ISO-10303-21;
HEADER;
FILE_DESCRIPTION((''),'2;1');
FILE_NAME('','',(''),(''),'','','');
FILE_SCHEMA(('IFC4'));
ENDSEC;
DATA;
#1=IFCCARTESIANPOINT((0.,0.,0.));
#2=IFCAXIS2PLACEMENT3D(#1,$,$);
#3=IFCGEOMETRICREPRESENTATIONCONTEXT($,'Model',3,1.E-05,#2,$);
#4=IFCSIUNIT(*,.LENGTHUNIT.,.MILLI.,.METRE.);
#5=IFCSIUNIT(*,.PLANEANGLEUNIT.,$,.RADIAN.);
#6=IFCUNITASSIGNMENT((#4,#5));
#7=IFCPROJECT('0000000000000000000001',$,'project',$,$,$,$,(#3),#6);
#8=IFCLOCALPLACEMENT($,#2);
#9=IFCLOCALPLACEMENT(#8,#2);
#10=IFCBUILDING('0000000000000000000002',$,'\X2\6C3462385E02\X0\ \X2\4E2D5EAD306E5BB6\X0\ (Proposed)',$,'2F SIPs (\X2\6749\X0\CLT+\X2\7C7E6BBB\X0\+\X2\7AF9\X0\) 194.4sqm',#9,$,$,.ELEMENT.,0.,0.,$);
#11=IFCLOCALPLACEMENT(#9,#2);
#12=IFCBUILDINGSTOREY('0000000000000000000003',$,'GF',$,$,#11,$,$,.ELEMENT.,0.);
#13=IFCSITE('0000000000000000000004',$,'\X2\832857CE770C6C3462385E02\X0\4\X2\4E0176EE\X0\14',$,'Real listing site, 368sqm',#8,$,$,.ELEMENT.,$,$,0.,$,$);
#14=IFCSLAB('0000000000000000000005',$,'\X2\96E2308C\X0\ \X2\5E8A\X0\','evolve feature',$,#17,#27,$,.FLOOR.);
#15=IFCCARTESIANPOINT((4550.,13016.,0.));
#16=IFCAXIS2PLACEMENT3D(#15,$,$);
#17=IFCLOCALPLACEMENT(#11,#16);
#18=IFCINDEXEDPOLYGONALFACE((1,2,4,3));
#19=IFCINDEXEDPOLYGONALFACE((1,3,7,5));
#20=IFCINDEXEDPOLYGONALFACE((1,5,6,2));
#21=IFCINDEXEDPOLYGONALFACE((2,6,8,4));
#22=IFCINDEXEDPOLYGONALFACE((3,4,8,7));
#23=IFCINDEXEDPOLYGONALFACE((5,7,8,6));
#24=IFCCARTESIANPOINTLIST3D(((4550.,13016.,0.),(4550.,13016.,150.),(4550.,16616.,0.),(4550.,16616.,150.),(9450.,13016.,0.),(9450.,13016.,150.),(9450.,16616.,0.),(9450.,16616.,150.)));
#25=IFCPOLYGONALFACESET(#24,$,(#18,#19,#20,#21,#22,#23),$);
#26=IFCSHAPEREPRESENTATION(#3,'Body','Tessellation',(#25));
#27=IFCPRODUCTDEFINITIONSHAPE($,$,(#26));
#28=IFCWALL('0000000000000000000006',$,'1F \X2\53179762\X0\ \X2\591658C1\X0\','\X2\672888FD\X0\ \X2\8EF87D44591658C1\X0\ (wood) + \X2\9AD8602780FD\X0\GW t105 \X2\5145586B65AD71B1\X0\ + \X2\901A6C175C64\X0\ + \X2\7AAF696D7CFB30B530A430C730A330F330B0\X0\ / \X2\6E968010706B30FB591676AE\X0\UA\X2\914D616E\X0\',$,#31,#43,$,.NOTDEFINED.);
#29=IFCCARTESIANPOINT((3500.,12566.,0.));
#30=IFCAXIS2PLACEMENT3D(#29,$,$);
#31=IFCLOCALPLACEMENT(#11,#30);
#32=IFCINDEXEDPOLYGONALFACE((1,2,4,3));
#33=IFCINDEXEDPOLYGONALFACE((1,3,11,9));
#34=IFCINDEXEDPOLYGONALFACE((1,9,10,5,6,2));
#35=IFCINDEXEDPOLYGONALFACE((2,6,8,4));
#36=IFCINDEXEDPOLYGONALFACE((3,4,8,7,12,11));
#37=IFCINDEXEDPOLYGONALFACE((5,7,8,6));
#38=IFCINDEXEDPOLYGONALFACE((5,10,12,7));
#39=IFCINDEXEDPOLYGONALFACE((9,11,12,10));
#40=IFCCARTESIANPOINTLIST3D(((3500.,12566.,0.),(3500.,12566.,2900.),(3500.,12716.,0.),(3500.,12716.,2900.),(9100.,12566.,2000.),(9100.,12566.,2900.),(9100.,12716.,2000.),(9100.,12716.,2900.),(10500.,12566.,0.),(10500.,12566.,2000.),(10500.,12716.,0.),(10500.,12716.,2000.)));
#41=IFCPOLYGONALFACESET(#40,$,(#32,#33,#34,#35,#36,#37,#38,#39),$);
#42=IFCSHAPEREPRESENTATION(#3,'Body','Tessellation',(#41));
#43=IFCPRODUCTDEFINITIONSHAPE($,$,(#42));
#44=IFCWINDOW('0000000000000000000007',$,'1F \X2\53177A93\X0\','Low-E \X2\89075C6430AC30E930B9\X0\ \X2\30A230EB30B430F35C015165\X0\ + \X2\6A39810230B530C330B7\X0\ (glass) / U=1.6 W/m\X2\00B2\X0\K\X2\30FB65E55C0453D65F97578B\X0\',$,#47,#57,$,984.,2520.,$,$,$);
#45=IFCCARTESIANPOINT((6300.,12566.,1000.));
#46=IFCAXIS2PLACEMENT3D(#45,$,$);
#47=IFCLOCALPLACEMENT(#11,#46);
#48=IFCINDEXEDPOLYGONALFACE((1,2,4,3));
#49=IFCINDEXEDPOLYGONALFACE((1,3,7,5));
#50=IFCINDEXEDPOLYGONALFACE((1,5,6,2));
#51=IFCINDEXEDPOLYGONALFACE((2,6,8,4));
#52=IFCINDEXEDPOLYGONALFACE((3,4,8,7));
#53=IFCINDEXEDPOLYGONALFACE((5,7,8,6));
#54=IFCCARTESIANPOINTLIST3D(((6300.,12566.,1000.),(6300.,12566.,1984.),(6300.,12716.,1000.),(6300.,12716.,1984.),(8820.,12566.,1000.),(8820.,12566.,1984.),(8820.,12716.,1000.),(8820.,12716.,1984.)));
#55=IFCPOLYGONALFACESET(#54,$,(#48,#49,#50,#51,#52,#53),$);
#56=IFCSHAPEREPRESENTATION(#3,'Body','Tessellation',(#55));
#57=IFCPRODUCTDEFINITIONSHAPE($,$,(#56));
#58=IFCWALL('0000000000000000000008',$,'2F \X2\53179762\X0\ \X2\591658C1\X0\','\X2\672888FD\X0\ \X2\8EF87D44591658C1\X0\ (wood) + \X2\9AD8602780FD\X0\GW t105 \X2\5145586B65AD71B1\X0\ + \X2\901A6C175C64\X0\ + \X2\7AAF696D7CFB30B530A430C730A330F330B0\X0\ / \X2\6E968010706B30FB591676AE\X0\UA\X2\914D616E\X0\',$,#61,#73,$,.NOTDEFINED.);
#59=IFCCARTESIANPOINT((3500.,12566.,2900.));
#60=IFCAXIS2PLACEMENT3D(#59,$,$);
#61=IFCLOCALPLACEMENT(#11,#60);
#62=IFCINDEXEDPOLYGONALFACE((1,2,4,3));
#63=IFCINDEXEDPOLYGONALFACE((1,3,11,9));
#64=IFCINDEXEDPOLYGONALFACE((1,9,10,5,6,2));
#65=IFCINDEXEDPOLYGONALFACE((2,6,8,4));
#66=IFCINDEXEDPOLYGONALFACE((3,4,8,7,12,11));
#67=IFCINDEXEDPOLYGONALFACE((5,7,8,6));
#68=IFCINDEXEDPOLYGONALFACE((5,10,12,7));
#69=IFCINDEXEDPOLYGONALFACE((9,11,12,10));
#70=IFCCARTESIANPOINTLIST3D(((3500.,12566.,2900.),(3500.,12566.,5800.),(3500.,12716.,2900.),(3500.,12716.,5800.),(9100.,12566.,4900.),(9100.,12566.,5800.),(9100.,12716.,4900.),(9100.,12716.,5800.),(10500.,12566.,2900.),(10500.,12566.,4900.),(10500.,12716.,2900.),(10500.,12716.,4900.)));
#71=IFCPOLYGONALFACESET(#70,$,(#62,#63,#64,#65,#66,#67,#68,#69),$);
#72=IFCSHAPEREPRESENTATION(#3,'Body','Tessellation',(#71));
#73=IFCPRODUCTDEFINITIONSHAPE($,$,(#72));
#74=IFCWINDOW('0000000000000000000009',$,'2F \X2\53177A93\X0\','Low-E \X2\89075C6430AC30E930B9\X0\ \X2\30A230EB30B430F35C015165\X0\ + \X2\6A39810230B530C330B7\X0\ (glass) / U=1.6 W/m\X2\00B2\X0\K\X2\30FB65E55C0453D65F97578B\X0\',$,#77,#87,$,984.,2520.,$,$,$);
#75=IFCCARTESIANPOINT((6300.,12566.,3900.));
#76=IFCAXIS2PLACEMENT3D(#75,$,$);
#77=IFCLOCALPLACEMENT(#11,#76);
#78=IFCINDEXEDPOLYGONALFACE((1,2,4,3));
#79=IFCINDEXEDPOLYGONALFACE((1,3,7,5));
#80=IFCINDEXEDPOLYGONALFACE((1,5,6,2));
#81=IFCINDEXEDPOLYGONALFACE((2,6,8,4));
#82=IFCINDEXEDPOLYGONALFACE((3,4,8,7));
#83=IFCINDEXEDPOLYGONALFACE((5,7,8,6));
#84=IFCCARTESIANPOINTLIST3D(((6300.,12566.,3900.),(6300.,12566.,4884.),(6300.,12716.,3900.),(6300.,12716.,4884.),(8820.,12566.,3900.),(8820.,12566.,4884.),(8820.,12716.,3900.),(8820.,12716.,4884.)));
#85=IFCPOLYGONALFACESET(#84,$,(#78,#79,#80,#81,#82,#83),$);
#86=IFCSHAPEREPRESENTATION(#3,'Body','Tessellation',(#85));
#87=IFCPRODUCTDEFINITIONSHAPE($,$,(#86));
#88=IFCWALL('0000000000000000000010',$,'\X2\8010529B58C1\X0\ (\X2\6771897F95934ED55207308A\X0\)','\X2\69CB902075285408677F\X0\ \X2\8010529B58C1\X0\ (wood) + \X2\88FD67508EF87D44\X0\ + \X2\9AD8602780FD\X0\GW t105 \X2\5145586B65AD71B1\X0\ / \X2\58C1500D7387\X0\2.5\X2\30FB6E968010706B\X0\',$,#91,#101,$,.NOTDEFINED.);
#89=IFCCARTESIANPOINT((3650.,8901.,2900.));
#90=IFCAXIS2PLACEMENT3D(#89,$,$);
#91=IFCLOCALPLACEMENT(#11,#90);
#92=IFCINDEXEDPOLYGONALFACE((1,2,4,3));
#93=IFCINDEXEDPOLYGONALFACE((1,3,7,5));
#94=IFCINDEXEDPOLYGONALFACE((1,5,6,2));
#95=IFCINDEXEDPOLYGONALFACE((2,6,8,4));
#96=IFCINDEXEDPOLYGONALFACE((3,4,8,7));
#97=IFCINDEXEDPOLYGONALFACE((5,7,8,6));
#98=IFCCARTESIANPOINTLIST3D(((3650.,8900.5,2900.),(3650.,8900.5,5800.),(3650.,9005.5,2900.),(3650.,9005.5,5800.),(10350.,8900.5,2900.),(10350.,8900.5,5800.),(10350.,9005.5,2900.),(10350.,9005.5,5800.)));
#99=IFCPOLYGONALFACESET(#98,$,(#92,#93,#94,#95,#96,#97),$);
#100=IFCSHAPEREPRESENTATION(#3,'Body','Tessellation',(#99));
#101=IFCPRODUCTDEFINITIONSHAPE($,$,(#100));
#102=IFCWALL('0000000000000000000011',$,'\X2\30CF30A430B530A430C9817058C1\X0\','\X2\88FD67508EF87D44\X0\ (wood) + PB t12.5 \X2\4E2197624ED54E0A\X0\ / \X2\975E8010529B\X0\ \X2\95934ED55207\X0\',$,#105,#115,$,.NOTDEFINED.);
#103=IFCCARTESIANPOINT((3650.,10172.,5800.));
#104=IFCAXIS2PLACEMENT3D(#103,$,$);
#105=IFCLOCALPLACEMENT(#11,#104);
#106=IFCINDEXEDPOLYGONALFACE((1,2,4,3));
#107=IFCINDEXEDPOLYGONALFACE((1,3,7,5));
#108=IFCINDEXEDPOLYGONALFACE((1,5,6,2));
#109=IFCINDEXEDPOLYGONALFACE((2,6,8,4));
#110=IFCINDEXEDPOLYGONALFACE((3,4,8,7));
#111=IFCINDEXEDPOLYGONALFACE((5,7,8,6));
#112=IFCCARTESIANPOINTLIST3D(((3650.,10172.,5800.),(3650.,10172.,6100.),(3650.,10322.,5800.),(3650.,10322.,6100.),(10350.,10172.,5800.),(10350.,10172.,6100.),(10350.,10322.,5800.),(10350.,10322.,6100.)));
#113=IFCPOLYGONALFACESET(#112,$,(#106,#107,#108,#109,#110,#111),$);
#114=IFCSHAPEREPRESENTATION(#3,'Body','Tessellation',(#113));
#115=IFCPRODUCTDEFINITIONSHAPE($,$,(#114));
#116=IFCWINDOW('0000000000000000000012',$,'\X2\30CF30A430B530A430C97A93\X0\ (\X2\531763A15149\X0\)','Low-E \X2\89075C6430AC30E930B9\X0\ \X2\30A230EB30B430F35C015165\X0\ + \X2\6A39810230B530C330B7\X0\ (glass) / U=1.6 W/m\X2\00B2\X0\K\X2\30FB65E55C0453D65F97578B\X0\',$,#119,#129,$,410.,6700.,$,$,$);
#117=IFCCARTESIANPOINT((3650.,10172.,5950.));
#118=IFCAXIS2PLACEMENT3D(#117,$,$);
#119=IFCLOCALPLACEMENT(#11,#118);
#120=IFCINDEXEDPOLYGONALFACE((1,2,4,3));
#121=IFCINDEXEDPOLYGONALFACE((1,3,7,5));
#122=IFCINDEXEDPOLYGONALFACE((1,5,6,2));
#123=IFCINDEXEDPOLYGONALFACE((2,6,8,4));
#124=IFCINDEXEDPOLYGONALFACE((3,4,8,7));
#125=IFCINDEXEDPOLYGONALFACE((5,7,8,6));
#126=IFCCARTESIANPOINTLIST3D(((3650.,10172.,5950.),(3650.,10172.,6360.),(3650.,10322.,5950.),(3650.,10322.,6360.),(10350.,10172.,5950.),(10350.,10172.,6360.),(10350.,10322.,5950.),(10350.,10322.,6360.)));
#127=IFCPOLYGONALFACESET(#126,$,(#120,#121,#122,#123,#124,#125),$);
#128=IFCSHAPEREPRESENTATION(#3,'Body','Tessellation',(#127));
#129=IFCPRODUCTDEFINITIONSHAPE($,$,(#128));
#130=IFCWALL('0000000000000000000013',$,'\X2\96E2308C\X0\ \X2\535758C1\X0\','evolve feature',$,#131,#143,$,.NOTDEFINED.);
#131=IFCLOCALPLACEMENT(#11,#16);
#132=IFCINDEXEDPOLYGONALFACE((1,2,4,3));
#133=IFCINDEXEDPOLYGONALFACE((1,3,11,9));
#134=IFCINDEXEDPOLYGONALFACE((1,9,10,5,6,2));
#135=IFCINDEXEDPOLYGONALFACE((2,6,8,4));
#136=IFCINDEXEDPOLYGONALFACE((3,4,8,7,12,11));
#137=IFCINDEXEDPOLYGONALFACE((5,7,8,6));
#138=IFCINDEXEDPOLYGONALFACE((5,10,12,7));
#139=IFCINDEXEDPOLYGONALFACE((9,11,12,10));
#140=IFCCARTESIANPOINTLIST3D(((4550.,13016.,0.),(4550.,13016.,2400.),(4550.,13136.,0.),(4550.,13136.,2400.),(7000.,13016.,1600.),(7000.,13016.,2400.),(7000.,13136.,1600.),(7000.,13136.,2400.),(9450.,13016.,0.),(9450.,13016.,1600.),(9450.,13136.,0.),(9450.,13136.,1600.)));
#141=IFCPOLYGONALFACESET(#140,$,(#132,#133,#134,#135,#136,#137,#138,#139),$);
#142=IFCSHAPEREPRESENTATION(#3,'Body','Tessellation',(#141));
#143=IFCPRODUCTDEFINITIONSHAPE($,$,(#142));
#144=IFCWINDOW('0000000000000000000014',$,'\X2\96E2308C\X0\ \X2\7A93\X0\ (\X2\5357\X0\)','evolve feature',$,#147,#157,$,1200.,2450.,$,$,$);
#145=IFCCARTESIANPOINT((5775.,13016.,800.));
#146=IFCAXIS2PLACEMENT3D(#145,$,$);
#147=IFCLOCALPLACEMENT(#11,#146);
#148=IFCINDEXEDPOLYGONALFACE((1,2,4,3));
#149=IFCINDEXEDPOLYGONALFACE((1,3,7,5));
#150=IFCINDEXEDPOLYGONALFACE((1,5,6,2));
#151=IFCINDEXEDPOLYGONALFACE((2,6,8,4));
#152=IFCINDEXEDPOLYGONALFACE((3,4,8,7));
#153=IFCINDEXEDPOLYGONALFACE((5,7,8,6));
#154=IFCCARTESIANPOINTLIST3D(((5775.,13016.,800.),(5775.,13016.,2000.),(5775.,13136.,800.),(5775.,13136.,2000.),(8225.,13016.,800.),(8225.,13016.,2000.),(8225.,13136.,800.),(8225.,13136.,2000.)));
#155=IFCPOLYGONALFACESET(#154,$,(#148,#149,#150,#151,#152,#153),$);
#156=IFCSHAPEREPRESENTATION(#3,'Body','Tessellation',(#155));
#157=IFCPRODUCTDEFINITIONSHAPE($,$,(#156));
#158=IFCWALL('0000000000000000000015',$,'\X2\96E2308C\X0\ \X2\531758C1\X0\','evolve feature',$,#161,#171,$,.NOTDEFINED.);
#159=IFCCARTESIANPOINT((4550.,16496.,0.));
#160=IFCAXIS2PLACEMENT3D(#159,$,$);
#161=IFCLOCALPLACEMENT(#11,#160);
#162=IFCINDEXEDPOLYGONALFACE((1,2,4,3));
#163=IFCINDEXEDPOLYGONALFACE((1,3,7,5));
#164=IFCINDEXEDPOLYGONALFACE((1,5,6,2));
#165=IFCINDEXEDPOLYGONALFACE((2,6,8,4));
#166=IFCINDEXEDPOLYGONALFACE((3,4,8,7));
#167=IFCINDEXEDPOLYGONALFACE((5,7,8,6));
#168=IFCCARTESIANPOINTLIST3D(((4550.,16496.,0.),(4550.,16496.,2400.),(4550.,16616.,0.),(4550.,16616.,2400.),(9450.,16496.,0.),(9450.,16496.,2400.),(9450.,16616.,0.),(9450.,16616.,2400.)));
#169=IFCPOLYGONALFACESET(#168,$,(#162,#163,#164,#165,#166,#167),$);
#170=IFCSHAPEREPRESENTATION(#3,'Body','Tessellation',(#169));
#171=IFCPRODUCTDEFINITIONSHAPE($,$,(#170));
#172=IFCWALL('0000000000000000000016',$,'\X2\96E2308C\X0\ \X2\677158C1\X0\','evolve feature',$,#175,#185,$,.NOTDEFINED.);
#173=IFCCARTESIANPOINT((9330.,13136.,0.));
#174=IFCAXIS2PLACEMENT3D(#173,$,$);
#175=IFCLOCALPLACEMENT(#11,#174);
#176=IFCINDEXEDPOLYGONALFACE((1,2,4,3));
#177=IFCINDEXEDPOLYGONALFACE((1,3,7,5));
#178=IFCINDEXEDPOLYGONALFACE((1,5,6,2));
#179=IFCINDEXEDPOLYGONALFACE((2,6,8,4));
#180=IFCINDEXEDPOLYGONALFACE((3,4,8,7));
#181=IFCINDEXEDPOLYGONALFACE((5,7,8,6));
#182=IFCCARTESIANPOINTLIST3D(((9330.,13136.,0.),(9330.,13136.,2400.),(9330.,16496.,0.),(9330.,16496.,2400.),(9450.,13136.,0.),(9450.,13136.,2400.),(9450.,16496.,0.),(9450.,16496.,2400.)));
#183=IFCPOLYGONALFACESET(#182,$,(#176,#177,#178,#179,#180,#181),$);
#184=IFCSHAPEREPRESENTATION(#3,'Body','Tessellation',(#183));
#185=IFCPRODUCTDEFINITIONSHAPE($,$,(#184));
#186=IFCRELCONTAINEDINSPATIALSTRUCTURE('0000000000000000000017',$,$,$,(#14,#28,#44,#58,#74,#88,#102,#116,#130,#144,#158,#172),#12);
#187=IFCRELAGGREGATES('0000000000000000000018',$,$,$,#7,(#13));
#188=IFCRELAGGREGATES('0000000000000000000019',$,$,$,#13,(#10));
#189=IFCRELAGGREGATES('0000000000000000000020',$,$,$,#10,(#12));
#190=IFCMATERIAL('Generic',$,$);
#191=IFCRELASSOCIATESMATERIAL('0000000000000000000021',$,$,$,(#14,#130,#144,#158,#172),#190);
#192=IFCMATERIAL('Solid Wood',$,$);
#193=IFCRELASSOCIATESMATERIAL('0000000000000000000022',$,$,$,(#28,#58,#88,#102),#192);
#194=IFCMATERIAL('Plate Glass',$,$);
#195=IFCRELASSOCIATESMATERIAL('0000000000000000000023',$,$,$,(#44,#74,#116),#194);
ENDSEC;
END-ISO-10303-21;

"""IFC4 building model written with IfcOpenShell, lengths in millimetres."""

from ifc_helpers import new_model, si_unit, frame, frame_2d, origin, place, context, project, spatial, rectangle, extrude, material, element, fill, save


model = new_model("IFC4")

# Units and contexts
model_context = context("Model", 3, precision=1e-05, world=origin())
ifc_project = project(units=[si_unit("LENGTHUNIT", "METRE", prefix="MILLI"), si_unit("PLANEANGLEUNIT", "RADIAN")], contexts=[model_context])

# Site, building, storey
site_placement = place(None, origin())
site = spatial("IfcSite", under=ifc_project, at=site_placement, Name="茨城県水戸市4丁目14", ObjectType="Real listing site, 368sqm", CompositionType="ELEMENT", RefElevation=0.0)
building_placement = place(site_placement, origin())
building = spatial("IfcBuilding", under=site, at=building_placement, Name="水戸市 中庭の家 (Proposed)", ObjectType="2F SIPs (杉CLT+籾殻+竹) 194.4sqm", CompositionType="ELEMENT", ElevationOfRefHeight=0.0, ElevationOfTerrain=0.0)
storey_placement = place(building_placement, origin())
storey = spatial("IfcBuildingStorey", under=building, at=storey_placement, Name="GF", CompositionType="ELEMENT", Elevation=0.0)

# Slab
ifc_material_1 = material(Name="Generic")
slab_placement = place(storey_placement, frame((4550.0, 13016.0, 0.0)))
element("IfcSlab", 1, at=slab_placement, inside=storey, material=ifc_material_1, Name="離れ 床", Description="evolve feature", PredefinedType="FLOOR", context=model_context, shape_type="SweptSolid", body=[
    extrude(rectangle(XDim=4900.0, YDim=3600.0, at=frame_2d((2450.0, 1800.0))), frame((4550.0, 13016.0, 0.0)), (0.0, 0.0, 1.0), 150.0),
])

# Wall, opening, window
ifc_material_2 = material(Name="Solid Wood")
wall_1_placement = place(storey_placement, frame((3500.0, 12566.0, 0.0)))
wall_1 = element("IfcWall", 2, at=wall_1_placement, inside=storey, material=ifc_material_2, Name="1F 北面 外壁", Description="木製 軸組外壁 (wood) + 高性能GW t105 充填断熱 + 通気層 + 窯業系サイディング / 準耐火・外皮UA配慮", PredefinedType="NOTDEFINED", context=model_context, shape_type="SweptSolid", body=[
    extrude(rectangle(XDim=7000.0, YDim=150.0, at=frame_2d((3500.0, 75.0))), frame((3500.0, 12566.0, 0.0)), (0.0, 0.0, 1.0), 2900.0),
])
opening_1_placement = place(storey_placement, frame((6300.0, 12566.0, 1000.0)))
opening_1 = element("IfcOpeningElement", 3, at=opening_1_placement, cuts=wall_1, PredefinedType="NOTDEFINED", context=model_context, shape_type="SweptSolid", body=[
    extrude(rectangle(XDim=2520.0, YDim=150.0, at=frame_2d((1260.0, 75.0))), frame((6300.0, 12566.0, 1000.0)), (0.0, 0.0, 1.0), 984.0),
])
ifc_material_3 = material(Name="Plate Glass")
window_1_placement = place(storey_placement, frame((6300.0, 12566.0, 1000.0)))
window_1 = element("IfcWindow", 4, at=window_1_placement, inside=storey, material=ifc_material_3, Name="1F 北窓", Description="Low-E 複層ガラス アルゴン封入 + 樹脂サッシ (glass) / U=1.6 W/m²K・日射取得型", OverallHeight=984.0, OverallWidth=2520.0, context=model_context, shape_type="SweptSolid", body=[
    extrude(rectangle(XDim=2520.0, YDim=150.0, at=frame_2d((1260.0, 75.0))), frame((6300.0, 12566.0, 1000.0)), (0.0, 0.0, 1.0), 984.0),
])
fill(opening_1, window_1)

# Wall, opening, window
wall_2_placement = place(storey_placement, frame((3500.0, 12566.0, 2900.0)))
wall_2 = element("IfcWall", 5, at=wall_2_placement, inside=storey, material=ifc_material_2, Name="2F 北面 外壁", Description="木製 軸組外壁 (wood) + 高性能GW t105 充填断熱 + 通気層 + 窯業系サイディング / 準耐火・外皮UA配慮", PredefinedType="NOTDEFINED", context=model_context, shape_type="SweptSolid", body=[
    extrude(rectangle(XDim=7000.0, YDim=150.0, at=frame_2d((3500.0, 75.0))), frame((3500.0, 12566.0, 2900.0)), (0.0, 0.0, 1.0), 2900.0),
])
opening_2_placement = place(storey_placement, frame((6300.0, 12566.0, 3900.0)))
opening_2 = element("IfcOpeningElement", 6, at=opening_2_placement, cuts=wall_2, PredefinedType="NOTDEFINED", context=model_context, shape_type="SweptSolid", body=[
    extrude(rectangle(XDim=2520.0, YDim=150.0, at=frame_2d((1260.0, 75.0))), frame((6300.0, 12566.0, 3900.0)), (0.0, 0.0, 1.0), 984.0),
])
window_2_placement = place(storey_placement, frame((6300.0, 12566.0, 3900.0)))
window_2 = element("IfcWindow", 7, at=window_2_placement, inside=storey, material=ifc_material_3, Name="2F 北窓", Description="Low-E 複層ガラス アルゴン封入 + 樹脂サッシ (glass) / U=1.6 W/m²K・日射取得型", OverallHeight=984.0, OverallWidth=2520.0, context=model_context, shape_type="SweptSolid", body=[
    extrude(rectangle(XDim=2520.0, YDim=150.0, at=frame_2d((1260.0, 75.0))), frame((6300.0, 12566.0, 3900.0)), (0.0, 0.0, 1.0), 984.0),
])
fill(opening_2, window_2)

# Wall
wall_3_placement = place(storey_placement, frame((3650.0, 8901.0, 2900.0)))
element("IfcWall", 8, at=wall_3_placement, inside=storey, material=ifc_material_2, Name="耐力壁 (東西間仕切り)", Description="構造用合板 耐力壁 (wood) + 製材軸組 + 高性能GW t105 充填断熱 / 壁倍率2.5・準耐火", PredefinedType="NOTDEFINED", context=model_context, shape_type="SweptSolid", body=[
    extrude(rectangle(XDim=6700.0, YDim=105.0, at=frame_2d((3350.0, 52.0))), frame((3650.0, 8901.0, 2900.0)), (0.0, 0.0, 1.0), 2900.0),
])

# Walls, openings, windows
wall_4_placement = place(storey_placement, frame((3650.0, 10172.0, 5800.0)))
wall_4 = element("IfcWall", 9, at=wall_4_placement, inside=storey, material=ifc_material_2, Name="ハイサイド腰壁", Description="製材軸組 (wood) + PB t12.5 両面仕上 / 非耐力 間仕切", PredefinedType="NOTDEFINED", context=model_context, shape_type="SweptSolid", body=[
    extrude(rectangle(XDim=6700.0, YDim=150.0, at=frame_2d((3350.0, 75.0))), frame((3650.0, 10172.0, 5800.0)), (0.0, 0.0, 1.0), 700.0),
])
opening_3_placement = place(storey_placement, frame((3650.0, 10172.0, 5950.0)))
opening_3 = element("IfcOpeningElement", 10, at=opening_3_placement, cuts=wall_4, PredefinedType="NOTDEFINED", context=model_context, shape_type="SweptSolid", body=[
    extrude(rectangle(XDim=6700.0, YDim=150.0, at=frame_2d((3350.0, 75.0))), frame((3650.0, 10172.0, 5950.0)), (0.0, 0.0, 1.0), 410.0),
])
window_3_placement = place(storey_placement, frame((3650.0, 10172.0, 5950.0)))
window_3 = element("IfcWindow", 11, at=window_3_placement, inside=storey, material=ifc_material_3, Name="ハイサイド窓 (北採光)", Description="Low-E 複層ガラス アルゴン封入 + 樹脂サッシ (glass) / U=1.6 W/m²K・日射取得型", OverallHeight=410.0, OverallWidth=6700.0, context=model_context, shape_type="SweptSolid", body=[
    extrude(rectangle(XDim=6700.0, YDim=150.0, at=frame_2d((3350.0, 75.0))), frame((3650.0, 10172.0, 5950.0)), (0.0, 0.0, 1.0), 410.0),
])
fill(opening_3, window_3)
wall_5_placement = place(storey_placement, frame((4550.0, 13016.0, 0.0)))
wall_5 = element("IfcWall", 12, at=wall_5_placement, inside=storey, material=ifc_material_1, Name="離れ 南壁", Description="evolve feature", PredefinedType="NOTDEFINED", context=model_context, shape_type="SweptSolid", body=[
    extrude(rectangle(XDim=4900.0, YDim=120.0, at=frame_2d((2450.0, 60.0))), frame((4550.0, 13016.0, 0.0)), (0.0, 0.0, 1.0), 2400.0),
])
opening_4_placement = place(storey_placement, frame((5775.0, 13016.0, 800.0)))
opening_4 = element("IfcOpeningElement", 13, at=opening_4_placement, cuts=wall_5, PredefinedType="NOTDEFINED", context=model_context, shape_type="SweptSolid", body=[
    extrude(rectangle(XDim=2450.0, YDim=120.0, at=frame_2d((1225.0, 60.0))), frame((5775.0, 13016.0, 800.0)), (0.0, 0.0, 1.0), 1200.0),
])
window_4_placement = place(storey_placement, frame((5775.0, 13016.0, 800.0)))
window_4 = element("IfcWindow", 14, at=window_4_placement, inside=storey, material=ifc_material_1, Name="離れ 窓 (南)", Description="evolve feature", OverallHeight=1200.0, OverallWidth=2450.0, context=model_context, shape_type="SweptSolid", body=[
    extrude(rectangle(XDim=2450.0, YDim=120.0, at=frame_2d((1225.0, 60.0))), frame((5775.0, 13016.0, 800.0)), (0.0, 0.0, 1.0), 1200.0),
])
fill(opening_4, window_4)

# Walls
wall_6_placement = place(storey_placement, frame((4550.0, 16496.0, 0.0)))
element("IfcWall", 15, at=wall_6_placement, inside=storey, material=ifc_material_1, Name="離れ 北壁", Description="evolve feature", PredefinedType="NOTDEFINED", context=model_context, shape_type="SweptSolid", body=[
    extrude(rectangle(XDim=4900.0, YDim=120.0, at=frame_2d((2450.0, 60.0))), frame((4550.0, 16496.0, 0.0)), (0.0, 0.0, 1.0), 2400.0),
])
wall_7_placement = place(storey_placement, frame((9330.0, 13136.0, 0.0)))
element("IfcWall", 16, at=wall_7_placement, inside=storey, material=ifc_material_1, Name="離れ 東壁", Description="evolve feature", PredefinedType="NOTDEFINED", context=model_context, shape_type="SweptSolid", body=[
    extrude(rectangle(XDim=120.0, YDim=3360.0, at=frame_2d((60.0, 1680.0))), frame((9330.0, 13136.0, 0.0)), (0.0, 0.0, 1.0), 2400.0),
])

save(model, "model.ifc")
